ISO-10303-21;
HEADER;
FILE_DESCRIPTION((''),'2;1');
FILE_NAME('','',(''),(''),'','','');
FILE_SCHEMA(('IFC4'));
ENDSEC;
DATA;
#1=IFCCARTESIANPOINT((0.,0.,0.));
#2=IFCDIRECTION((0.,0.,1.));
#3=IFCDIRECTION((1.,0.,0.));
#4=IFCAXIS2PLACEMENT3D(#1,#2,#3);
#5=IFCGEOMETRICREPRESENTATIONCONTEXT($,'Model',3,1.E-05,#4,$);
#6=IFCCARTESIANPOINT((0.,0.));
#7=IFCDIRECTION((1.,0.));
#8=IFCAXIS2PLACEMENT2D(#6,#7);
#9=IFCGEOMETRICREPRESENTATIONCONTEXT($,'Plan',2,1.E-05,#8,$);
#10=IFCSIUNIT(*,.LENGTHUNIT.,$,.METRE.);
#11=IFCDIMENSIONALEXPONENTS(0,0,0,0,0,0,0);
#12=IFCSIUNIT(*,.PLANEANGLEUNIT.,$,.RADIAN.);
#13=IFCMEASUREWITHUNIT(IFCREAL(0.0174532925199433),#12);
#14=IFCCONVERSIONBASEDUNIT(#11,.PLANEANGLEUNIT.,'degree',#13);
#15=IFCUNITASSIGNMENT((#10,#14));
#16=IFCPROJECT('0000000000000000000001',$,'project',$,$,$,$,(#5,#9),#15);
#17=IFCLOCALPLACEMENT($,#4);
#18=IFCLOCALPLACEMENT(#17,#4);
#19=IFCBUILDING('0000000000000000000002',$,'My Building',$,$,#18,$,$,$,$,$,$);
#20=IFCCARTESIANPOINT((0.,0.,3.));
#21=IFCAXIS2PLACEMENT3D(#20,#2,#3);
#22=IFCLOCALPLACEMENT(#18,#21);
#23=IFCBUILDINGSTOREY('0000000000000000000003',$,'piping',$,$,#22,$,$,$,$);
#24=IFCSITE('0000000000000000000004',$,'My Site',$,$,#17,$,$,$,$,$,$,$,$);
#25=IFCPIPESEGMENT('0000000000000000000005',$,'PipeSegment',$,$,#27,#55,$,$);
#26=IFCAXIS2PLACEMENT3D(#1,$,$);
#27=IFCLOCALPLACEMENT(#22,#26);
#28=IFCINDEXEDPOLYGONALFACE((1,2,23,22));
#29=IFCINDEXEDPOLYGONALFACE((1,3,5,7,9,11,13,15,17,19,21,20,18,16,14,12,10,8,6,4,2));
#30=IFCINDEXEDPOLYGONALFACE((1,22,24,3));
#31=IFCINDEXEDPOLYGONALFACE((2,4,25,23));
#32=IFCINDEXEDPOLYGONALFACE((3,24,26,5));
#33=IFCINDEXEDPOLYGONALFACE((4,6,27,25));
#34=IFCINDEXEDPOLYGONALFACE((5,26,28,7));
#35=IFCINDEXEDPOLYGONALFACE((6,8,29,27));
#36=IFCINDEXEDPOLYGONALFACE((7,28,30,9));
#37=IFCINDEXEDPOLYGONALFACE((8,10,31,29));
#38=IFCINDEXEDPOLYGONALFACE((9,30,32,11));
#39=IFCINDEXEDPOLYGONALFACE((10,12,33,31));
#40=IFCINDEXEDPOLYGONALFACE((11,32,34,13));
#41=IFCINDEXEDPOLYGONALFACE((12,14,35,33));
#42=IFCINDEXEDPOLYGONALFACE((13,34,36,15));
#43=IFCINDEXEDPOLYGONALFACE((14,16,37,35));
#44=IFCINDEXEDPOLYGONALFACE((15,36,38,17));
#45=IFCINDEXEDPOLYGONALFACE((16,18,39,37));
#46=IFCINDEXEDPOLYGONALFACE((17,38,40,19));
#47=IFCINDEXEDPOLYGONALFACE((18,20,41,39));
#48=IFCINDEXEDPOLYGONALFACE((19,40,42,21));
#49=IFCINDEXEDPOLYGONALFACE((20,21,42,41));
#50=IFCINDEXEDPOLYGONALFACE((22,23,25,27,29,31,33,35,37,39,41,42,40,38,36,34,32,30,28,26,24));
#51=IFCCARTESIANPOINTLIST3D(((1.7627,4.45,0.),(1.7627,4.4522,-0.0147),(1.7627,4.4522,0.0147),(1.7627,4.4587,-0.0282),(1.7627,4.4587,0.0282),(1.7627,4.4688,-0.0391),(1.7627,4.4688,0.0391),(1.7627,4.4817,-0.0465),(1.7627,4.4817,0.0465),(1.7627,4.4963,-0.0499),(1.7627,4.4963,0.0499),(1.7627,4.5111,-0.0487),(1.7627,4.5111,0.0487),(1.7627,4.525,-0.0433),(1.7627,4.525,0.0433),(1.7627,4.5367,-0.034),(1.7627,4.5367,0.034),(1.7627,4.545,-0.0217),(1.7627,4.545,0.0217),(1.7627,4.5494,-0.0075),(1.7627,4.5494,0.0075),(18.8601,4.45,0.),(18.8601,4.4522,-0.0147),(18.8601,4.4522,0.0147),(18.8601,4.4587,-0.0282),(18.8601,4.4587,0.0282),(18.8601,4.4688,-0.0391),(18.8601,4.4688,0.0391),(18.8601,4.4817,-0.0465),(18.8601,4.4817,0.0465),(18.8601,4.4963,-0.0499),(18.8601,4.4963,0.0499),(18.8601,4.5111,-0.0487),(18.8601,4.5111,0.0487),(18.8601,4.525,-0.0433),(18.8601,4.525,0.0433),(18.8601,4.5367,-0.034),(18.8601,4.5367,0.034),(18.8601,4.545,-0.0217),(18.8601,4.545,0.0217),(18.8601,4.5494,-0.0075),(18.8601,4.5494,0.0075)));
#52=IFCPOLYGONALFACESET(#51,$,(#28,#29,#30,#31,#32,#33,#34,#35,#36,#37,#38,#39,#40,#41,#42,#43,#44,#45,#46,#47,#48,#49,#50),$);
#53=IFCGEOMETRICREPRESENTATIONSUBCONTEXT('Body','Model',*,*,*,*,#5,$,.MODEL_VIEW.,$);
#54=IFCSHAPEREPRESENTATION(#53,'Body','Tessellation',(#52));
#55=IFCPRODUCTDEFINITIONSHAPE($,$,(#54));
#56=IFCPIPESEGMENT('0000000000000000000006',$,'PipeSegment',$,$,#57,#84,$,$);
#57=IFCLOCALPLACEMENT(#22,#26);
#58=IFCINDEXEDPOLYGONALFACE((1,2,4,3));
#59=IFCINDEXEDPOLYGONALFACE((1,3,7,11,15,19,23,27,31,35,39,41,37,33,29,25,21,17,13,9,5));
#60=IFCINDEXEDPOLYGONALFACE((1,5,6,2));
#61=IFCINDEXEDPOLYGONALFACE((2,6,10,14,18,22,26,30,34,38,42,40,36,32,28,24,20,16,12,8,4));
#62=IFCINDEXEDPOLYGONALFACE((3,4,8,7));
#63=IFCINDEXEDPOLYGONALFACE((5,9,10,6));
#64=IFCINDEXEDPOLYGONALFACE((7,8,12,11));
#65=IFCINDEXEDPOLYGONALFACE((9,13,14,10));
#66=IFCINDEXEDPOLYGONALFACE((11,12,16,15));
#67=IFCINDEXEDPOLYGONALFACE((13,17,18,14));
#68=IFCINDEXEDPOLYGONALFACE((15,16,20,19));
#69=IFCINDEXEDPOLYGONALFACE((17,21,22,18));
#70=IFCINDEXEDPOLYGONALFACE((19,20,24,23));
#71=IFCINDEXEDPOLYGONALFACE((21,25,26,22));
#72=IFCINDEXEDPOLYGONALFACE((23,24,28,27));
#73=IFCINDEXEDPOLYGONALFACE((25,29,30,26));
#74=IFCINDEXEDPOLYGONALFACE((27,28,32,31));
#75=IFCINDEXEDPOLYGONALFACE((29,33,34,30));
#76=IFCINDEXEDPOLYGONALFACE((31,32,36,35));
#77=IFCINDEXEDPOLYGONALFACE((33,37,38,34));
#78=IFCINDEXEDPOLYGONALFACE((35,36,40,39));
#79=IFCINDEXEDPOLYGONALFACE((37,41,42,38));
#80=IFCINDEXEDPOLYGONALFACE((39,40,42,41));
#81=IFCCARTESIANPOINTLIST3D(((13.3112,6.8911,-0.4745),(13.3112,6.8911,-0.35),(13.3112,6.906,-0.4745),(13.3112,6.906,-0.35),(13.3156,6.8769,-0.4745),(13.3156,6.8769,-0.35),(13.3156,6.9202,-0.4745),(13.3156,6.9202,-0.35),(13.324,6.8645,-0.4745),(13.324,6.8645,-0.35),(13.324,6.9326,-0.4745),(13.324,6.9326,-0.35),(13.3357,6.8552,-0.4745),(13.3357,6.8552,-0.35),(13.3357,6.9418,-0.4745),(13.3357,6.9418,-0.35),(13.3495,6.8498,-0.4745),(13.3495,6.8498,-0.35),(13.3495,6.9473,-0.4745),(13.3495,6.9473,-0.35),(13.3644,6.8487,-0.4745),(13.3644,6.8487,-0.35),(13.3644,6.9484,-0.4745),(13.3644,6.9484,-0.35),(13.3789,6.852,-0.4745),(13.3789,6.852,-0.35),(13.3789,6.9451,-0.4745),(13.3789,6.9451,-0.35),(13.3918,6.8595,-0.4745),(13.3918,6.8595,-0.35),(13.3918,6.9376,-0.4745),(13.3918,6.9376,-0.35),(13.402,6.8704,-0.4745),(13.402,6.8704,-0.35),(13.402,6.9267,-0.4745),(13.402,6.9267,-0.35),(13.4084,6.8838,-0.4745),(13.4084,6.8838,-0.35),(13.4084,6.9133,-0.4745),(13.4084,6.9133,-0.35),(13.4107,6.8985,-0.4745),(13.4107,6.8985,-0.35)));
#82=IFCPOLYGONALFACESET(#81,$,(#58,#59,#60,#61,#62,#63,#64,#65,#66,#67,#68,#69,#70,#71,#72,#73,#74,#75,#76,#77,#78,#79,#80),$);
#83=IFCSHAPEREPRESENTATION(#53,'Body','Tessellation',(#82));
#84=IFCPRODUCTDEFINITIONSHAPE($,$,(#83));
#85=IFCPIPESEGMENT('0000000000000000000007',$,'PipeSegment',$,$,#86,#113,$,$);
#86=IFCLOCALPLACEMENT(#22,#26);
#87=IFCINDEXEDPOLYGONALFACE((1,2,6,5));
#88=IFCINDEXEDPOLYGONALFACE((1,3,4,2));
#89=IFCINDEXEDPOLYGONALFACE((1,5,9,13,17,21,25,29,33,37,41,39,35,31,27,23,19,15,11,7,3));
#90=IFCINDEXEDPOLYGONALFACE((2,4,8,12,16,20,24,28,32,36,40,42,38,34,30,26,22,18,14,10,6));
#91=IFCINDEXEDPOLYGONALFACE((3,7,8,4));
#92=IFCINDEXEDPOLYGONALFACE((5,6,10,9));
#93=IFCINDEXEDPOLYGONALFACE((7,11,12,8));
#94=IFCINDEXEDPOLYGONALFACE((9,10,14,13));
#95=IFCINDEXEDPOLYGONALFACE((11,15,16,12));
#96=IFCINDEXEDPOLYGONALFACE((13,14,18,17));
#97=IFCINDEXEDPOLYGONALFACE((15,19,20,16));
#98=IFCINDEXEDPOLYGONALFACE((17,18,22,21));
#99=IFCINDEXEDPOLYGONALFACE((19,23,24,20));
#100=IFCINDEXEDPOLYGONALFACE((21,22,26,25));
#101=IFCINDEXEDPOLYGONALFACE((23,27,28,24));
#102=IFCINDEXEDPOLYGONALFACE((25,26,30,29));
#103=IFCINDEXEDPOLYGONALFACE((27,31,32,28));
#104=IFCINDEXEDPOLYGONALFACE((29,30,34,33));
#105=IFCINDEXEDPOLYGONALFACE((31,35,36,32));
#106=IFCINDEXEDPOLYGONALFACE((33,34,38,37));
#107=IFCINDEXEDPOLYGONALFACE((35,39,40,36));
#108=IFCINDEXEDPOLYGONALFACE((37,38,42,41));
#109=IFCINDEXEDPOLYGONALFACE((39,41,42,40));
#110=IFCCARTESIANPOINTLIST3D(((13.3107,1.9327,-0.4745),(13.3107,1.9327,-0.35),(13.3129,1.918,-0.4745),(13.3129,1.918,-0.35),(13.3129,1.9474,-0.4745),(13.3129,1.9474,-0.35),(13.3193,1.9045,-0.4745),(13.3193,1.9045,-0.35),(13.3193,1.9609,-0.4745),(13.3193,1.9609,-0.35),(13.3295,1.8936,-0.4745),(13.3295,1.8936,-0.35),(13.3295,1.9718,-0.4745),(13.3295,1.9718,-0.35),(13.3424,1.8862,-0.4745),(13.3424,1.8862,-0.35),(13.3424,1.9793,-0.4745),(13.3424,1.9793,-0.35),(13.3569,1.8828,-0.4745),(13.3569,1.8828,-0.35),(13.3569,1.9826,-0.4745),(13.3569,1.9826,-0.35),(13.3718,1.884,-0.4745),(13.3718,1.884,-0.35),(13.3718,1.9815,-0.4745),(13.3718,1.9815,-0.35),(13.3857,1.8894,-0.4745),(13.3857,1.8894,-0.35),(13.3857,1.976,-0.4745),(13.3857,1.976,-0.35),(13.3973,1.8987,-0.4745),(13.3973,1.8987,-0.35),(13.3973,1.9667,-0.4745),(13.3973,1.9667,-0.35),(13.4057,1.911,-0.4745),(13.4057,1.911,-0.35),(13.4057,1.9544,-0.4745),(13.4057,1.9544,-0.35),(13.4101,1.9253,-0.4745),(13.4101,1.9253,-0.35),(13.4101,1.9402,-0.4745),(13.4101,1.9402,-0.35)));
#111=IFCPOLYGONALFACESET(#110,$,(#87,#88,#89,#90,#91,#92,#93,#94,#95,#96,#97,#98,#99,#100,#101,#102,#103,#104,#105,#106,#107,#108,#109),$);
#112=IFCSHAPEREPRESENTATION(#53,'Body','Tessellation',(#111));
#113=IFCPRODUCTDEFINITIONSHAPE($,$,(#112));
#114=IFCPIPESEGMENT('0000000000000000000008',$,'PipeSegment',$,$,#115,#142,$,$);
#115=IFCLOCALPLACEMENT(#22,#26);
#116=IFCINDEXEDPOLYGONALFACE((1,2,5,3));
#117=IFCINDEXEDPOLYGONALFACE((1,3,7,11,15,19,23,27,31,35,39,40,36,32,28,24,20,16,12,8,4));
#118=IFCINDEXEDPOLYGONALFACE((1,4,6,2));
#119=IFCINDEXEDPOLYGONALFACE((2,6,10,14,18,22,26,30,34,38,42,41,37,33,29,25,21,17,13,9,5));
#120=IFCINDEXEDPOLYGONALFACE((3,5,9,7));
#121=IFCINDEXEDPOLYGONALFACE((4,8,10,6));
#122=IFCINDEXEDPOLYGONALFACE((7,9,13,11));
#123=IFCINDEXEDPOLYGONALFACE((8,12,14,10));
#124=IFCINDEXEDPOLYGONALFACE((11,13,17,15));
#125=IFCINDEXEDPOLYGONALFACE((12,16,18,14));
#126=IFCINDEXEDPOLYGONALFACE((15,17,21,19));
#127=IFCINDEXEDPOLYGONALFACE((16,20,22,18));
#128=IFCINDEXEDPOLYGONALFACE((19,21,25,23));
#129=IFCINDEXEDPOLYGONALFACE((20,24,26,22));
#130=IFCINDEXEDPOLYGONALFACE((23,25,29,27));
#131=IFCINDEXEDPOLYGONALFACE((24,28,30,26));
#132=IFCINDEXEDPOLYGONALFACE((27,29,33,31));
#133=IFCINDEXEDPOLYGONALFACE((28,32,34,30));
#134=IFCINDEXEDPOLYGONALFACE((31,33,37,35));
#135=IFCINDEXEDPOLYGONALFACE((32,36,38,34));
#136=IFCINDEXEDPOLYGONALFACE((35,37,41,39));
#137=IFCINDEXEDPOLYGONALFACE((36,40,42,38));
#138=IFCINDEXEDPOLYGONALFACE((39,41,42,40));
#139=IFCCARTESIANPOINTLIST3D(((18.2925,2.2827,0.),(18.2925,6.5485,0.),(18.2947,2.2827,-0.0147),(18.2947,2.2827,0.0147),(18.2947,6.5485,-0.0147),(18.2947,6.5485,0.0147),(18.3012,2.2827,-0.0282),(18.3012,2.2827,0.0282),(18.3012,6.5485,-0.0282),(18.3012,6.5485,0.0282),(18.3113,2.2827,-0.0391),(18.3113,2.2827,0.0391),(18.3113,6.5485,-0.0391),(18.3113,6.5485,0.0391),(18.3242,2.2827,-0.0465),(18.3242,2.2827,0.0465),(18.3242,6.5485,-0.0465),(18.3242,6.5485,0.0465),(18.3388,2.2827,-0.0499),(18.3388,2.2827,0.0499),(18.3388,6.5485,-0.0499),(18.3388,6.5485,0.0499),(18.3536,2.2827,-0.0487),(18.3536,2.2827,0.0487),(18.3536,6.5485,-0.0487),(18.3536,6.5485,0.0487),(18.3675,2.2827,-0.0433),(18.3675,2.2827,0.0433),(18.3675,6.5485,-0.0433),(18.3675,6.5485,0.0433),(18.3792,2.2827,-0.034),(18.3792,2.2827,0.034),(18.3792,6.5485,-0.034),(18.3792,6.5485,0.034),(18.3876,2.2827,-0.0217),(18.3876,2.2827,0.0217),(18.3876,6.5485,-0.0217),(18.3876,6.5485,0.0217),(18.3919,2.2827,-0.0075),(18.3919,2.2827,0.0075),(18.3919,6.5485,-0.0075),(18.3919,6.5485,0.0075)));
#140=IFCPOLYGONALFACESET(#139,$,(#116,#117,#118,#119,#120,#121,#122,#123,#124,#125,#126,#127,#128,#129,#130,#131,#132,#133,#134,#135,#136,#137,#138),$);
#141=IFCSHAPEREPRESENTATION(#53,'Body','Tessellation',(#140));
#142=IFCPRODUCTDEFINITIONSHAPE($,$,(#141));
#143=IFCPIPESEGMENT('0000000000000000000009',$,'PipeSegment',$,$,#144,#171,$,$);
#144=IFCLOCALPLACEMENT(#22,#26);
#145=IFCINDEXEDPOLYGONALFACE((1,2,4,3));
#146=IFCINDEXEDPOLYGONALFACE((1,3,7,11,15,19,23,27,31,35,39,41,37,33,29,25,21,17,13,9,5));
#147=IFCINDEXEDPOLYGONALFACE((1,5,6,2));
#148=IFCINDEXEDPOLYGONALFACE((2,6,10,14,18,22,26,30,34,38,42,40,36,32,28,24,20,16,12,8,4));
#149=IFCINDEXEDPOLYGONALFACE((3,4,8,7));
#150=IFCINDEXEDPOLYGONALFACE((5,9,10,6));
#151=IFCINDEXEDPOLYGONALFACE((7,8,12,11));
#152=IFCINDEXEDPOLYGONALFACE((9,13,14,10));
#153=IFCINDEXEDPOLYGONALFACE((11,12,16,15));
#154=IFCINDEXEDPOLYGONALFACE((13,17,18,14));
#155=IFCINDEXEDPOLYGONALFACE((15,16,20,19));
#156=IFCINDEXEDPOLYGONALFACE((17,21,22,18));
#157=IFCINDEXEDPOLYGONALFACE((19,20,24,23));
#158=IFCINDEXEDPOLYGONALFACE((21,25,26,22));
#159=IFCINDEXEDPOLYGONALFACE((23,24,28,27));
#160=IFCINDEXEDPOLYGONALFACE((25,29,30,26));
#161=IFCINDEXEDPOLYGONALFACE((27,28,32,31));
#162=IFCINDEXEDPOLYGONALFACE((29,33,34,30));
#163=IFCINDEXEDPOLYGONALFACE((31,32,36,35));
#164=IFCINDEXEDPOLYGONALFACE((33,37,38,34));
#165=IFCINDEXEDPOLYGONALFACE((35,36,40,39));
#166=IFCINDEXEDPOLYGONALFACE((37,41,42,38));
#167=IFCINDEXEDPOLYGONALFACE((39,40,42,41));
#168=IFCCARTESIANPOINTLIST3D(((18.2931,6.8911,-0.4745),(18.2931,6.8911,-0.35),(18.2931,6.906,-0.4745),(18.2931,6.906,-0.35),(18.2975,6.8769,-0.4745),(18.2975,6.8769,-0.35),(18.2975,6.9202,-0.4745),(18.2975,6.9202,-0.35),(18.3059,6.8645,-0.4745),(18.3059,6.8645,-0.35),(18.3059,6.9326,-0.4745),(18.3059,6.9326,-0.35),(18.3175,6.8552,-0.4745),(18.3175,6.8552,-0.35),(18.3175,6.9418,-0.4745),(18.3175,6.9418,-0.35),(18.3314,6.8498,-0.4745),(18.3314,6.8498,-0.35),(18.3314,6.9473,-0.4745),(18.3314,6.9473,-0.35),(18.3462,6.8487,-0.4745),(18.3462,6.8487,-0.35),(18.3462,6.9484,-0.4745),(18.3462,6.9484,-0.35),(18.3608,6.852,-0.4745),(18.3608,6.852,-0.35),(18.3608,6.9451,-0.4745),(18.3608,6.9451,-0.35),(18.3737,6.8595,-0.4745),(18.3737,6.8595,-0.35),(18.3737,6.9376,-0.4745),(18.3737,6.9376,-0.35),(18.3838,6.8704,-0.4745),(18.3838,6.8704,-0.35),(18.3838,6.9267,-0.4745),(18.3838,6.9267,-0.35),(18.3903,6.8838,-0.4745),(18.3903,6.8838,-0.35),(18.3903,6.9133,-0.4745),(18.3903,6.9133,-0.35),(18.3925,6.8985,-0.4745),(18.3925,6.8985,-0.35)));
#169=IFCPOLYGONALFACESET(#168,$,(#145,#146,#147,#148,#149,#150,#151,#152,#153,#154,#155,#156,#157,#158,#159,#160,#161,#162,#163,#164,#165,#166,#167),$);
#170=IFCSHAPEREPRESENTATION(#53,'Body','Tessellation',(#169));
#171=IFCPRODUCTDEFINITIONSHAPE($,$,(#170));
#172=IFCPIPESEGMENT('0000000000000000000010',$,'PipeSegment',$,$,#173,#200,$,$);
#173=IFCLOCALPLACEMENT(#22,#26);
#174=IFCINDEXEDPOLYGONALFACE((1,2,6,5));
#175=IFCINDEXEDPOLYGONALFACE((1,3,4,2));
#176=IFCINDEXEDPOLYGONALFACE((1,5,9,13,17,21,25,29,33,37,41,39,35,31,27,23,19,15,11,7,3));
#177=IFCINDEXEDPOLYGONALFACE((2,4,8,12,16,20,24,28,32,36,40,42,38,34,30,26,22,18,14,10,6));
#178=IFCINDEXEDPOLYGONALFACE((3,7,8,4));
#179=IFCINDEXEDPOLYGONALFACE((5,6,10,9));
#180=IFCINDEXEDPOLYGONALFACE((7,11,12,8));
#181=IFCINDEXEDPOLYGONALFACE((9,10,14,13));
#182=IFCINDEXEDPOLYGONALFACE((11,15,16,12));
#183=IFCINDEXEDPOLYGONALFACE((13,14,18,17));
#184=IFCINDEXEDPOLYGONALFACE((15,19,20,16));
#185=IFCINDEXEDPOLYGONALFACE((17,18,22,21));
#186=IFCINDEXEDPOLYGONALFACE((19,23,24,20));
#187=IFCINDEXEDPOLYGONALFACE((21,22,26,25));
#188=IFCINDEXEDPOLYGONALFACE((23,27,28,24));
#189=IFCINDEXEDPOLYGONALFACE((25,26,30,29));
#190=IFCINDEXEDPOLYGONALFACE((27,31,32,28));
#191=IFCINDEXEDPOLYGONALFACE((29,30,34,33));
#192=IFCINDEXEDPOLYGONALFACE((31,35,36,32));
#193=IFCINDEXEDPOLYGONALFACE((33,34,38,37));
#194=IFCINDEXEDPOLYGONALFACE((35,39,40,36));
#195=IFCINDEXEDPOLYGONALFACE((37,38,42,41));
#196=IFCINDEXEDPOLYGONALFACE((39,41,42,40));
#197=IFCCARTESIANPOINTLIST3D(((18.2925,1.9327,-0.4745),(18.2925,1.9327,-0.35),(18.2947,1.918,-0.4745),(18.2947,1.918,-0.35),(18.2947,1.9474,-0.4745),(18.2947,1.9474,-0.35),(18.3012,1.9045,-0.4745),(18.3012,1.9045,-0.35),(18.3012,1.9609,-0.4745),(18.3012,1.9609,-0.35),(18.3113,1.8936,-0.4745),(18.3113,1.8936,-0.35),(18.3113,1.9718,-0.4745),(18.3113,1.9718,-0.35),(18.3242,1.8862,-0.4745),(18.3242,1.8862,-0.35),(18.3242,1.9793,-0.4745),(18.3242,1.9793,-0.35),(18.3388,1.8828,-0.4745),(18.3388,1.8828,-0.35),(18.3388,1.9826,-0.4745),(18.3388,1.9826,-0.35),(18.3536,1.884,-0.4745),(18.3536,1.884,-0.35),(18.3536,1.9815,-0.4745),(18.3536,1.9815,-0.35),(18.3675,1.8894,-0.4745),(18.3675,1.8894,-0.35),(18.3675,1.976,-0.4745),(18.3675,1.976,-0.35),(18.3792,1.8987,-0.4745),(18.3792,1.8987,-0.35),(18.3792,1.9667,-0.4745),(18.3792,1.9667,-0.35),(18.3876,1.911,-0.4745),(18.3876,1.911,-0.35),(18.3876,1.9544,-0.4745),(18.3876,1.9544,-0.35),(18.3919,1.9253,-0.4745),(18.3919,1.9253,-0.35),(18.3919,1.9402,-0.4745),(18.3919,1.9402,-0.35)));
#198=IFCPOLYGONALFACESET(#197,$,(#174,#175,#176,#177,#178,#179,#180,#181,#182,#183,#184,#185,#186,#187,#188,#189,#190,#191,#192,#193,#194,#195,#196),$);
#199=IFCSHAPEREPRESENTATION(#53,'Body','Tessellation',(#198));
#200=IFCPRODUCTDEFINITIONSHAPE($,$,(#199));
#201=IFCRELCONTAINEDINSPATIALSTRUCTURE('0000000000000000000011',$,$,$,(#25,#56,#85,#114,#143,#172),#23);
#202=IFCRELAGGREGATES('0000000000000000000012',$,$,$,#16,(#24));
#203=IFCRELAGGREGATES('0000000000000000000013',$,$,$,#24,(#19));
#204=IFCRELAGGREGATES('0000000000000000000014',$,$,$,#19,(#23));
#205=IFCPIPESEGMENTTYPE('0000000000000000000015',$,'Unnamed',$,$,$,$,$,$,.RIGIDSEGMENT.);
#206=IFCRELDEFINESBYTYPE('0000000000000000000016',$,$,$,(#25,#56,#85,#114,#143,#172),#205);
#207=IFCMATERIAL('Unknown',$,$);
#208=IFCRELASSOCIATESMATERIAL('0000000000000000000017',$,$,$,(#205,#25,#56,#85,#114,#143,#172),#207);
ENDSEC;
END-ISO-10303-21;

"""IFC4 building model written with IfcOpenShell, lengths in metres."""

from ifc_helpers import new_model, entity, si_unit, converted_unit, frame, origin_with_axes, origin_2d_with_axis, place, context, subcontext, project, spatial, circle, extrude, material, material_profile, profile_set, profile_usage, type_object, element, save


model = new_model("IFC4")

# Units and contexts
model_context = context("Model", 3, precision=1e-05, world=origin_with_axes())
plan_context = context("Plan", 2, precision=1e-05, world=origin_2d_with_axis())
body_context = subcontext(model_context, "Body", "Model", "MODEL_VIEW")
ifc_project = project(units=[si_unit("LENGTHUNIT", "METRE"), converted_unit("PLANEANGLEUNIT", "degree", entity("IfcReal", 0.0174532925199433), si_unit("PLANEANGLEUNIT", "RADIAN"), dimensions=[0, 0, 0, 0, 0, 0, 0])], contexts=[model_context, plan_context])

# Site, building, storey
site_placement = place(None, origin_with_axes())
site = spatial("IfcSite", under=ifc_project, at=site_placement, Name="My Site")
building_placement = place(site_placement, origin_with_axes())
building = spatial("IfcBuilding", under=site, at=building_placement, Name="My Building")
storey_placement = place(building_placement, frame((0.0, 0.0, 3.0), z_axis=(0.0, 0.0, 1.0), x_axis=(1.0, 0.0, 0.0)))
storey = spatial("IfcBuildingStorey", under=building, at=storey_placement, Name="piping")

# Pipe segments
ifc_material = material(Name="Unknown")
ifc_material_profile = material_profile(ifc_material, circle(Radius=0.05))
ifc_profile_set = profile_set([ifc_material_profile])
ifc_profile_usage_1 = profile_usage(ifc_profile_set, cardinal=5)
pipe_segment_type = type_object("IfcPipeSegmentType", Name="Unnamed", PredefinedType="RIGIDSEGMENT", material=ifc_profile_set)
pipe_segment_1_placement = place(storey_placement, frame((18.8601, 4.5, 0.0), z_axis=(-1.0, 0.0, 0.0), x_axis=(0.0, -1.0, 0.0)))
element("IfcPipeSegment", 1, at=pipe_segment_1_placement, inside=storey, type_object=pipe_segment_type, material=ifc_profile_usage_1, Name="PipeSegment", context=body_context, shape_type="SweptSolid", body=[
    extrude(circle(Radius=0.05), origin_with_axes(), (0.0, 0.0, 1.0), 17.0974),
])
ifc_profile_usage_2 = profile_usage(ifc_profile_set, cardinal=5)
pipe_segment_2_placement = place(storey_placement, frame((13.3607, 6.8985, -0.35), z_axis=(0.0, 0.0, -1.0), x_axis=(1.0, 0.0, 0.0)))
element("IfcPipeSegment", 2, at=pipe_segment_2_placement, inside=storey, type_object=pipe_segment_type, material=ifc_profile_usage_2, Name="PipeSegment", context=body_context, shape_type="SweptSolid", body=[
    extrude(circle(Radius=0.05), origin_with_axes(), (0.0, 0.0, 1.0), 0.1245),
])
ifc_profile_usage_3 = profile_usage(ifc_profile_set, cardinal=5)
pipe_segment_3_placement = place(storey_placement, frame((13.3607, 1.9327, -0.35), z_axis=(0.0, 0.0, -1.0), x_axis=(-1.0, 0.0, 0.0)))
element("IfcPipeSegment", 3, at=pipe_segment_3_placement, inside=storey, type_object=pipe_segment_type, material=ifc_profile_usage_3, Name="PipeSegment", context=body_context, shape_type="SweptSolid", body=[
    extrude(circle(Radius=0.05), origin_with_axes(), (0.0, 0.0, 1.0), 0.1245),
])
ifc_profile_usage_4 = profile_usage(ifc_profile_set, cardinal=5)
pipe_segment_4_placement = place(storey_placement, frame((18.3425, 2.2827, 0.0), z_axis=(0.0, 1.0, 0.0), x_axis=(-1.0, 0.0, 0.0)))
element("IfcPipeSegment", 4, at=pipe_segment_4_placement, inside=storey, type_object=pipe_segment_type, material=ifc_profile_usage_4, Name="PipeSegment", context=body_context, shape_type="SweptSolid", body=[
    extrude(circle(Radius=0.05), origin_with_axes(), (0.0, 0.0, 1.0), 4.2658),
])
ifc_profile_usage_5 = profile_usage(ifc_profile_set, cardinal=5)
pipe_segment_5_placement = place(storey_placement, frame((18.3425, 6.8985, -0.35), z_axis=(0.0, 0.0, -1.0), x_axis=(1.0, 0.0, 0.0)))
element("IfcPipeSegment", 5, at=pipe_segment_5_placement, inside=storey, type_object=pipe_segment_type, material=ifc_profile_usage_5, Name="PipeSegment", context=body_context, shape_type="SweptSolid", body=[
    extrude(circle(Radius=0.05), origin_with_axes(), (0.0, 0.0, 1.0), 0.1245),
])
ifc_profile_usage_6 = profile_usage(ifc_profile_set, cardinal=5)
pipe_segment_6_placement = place(storey_placement, frame((18.3425, 1.9327, -0.35), z_axis=(0.0, 0.0, -1.0), x_axis=(-1.0, 0.0, 0.0)))
element("IfcPipeSegment", 6, at=pipe_segment_6_placement, inside=storey, type_object=pipe_segment_type, material=ifc_profile_usage_6, Name="PipeSegment", context=body_context, shape_type="SweptSolid", body=[
    extrude(circle(Radius=0.05), origin_with_axes(), (0.0, 0.0, 1.0), 0.1245),
])

save(model, "model.ifc")
